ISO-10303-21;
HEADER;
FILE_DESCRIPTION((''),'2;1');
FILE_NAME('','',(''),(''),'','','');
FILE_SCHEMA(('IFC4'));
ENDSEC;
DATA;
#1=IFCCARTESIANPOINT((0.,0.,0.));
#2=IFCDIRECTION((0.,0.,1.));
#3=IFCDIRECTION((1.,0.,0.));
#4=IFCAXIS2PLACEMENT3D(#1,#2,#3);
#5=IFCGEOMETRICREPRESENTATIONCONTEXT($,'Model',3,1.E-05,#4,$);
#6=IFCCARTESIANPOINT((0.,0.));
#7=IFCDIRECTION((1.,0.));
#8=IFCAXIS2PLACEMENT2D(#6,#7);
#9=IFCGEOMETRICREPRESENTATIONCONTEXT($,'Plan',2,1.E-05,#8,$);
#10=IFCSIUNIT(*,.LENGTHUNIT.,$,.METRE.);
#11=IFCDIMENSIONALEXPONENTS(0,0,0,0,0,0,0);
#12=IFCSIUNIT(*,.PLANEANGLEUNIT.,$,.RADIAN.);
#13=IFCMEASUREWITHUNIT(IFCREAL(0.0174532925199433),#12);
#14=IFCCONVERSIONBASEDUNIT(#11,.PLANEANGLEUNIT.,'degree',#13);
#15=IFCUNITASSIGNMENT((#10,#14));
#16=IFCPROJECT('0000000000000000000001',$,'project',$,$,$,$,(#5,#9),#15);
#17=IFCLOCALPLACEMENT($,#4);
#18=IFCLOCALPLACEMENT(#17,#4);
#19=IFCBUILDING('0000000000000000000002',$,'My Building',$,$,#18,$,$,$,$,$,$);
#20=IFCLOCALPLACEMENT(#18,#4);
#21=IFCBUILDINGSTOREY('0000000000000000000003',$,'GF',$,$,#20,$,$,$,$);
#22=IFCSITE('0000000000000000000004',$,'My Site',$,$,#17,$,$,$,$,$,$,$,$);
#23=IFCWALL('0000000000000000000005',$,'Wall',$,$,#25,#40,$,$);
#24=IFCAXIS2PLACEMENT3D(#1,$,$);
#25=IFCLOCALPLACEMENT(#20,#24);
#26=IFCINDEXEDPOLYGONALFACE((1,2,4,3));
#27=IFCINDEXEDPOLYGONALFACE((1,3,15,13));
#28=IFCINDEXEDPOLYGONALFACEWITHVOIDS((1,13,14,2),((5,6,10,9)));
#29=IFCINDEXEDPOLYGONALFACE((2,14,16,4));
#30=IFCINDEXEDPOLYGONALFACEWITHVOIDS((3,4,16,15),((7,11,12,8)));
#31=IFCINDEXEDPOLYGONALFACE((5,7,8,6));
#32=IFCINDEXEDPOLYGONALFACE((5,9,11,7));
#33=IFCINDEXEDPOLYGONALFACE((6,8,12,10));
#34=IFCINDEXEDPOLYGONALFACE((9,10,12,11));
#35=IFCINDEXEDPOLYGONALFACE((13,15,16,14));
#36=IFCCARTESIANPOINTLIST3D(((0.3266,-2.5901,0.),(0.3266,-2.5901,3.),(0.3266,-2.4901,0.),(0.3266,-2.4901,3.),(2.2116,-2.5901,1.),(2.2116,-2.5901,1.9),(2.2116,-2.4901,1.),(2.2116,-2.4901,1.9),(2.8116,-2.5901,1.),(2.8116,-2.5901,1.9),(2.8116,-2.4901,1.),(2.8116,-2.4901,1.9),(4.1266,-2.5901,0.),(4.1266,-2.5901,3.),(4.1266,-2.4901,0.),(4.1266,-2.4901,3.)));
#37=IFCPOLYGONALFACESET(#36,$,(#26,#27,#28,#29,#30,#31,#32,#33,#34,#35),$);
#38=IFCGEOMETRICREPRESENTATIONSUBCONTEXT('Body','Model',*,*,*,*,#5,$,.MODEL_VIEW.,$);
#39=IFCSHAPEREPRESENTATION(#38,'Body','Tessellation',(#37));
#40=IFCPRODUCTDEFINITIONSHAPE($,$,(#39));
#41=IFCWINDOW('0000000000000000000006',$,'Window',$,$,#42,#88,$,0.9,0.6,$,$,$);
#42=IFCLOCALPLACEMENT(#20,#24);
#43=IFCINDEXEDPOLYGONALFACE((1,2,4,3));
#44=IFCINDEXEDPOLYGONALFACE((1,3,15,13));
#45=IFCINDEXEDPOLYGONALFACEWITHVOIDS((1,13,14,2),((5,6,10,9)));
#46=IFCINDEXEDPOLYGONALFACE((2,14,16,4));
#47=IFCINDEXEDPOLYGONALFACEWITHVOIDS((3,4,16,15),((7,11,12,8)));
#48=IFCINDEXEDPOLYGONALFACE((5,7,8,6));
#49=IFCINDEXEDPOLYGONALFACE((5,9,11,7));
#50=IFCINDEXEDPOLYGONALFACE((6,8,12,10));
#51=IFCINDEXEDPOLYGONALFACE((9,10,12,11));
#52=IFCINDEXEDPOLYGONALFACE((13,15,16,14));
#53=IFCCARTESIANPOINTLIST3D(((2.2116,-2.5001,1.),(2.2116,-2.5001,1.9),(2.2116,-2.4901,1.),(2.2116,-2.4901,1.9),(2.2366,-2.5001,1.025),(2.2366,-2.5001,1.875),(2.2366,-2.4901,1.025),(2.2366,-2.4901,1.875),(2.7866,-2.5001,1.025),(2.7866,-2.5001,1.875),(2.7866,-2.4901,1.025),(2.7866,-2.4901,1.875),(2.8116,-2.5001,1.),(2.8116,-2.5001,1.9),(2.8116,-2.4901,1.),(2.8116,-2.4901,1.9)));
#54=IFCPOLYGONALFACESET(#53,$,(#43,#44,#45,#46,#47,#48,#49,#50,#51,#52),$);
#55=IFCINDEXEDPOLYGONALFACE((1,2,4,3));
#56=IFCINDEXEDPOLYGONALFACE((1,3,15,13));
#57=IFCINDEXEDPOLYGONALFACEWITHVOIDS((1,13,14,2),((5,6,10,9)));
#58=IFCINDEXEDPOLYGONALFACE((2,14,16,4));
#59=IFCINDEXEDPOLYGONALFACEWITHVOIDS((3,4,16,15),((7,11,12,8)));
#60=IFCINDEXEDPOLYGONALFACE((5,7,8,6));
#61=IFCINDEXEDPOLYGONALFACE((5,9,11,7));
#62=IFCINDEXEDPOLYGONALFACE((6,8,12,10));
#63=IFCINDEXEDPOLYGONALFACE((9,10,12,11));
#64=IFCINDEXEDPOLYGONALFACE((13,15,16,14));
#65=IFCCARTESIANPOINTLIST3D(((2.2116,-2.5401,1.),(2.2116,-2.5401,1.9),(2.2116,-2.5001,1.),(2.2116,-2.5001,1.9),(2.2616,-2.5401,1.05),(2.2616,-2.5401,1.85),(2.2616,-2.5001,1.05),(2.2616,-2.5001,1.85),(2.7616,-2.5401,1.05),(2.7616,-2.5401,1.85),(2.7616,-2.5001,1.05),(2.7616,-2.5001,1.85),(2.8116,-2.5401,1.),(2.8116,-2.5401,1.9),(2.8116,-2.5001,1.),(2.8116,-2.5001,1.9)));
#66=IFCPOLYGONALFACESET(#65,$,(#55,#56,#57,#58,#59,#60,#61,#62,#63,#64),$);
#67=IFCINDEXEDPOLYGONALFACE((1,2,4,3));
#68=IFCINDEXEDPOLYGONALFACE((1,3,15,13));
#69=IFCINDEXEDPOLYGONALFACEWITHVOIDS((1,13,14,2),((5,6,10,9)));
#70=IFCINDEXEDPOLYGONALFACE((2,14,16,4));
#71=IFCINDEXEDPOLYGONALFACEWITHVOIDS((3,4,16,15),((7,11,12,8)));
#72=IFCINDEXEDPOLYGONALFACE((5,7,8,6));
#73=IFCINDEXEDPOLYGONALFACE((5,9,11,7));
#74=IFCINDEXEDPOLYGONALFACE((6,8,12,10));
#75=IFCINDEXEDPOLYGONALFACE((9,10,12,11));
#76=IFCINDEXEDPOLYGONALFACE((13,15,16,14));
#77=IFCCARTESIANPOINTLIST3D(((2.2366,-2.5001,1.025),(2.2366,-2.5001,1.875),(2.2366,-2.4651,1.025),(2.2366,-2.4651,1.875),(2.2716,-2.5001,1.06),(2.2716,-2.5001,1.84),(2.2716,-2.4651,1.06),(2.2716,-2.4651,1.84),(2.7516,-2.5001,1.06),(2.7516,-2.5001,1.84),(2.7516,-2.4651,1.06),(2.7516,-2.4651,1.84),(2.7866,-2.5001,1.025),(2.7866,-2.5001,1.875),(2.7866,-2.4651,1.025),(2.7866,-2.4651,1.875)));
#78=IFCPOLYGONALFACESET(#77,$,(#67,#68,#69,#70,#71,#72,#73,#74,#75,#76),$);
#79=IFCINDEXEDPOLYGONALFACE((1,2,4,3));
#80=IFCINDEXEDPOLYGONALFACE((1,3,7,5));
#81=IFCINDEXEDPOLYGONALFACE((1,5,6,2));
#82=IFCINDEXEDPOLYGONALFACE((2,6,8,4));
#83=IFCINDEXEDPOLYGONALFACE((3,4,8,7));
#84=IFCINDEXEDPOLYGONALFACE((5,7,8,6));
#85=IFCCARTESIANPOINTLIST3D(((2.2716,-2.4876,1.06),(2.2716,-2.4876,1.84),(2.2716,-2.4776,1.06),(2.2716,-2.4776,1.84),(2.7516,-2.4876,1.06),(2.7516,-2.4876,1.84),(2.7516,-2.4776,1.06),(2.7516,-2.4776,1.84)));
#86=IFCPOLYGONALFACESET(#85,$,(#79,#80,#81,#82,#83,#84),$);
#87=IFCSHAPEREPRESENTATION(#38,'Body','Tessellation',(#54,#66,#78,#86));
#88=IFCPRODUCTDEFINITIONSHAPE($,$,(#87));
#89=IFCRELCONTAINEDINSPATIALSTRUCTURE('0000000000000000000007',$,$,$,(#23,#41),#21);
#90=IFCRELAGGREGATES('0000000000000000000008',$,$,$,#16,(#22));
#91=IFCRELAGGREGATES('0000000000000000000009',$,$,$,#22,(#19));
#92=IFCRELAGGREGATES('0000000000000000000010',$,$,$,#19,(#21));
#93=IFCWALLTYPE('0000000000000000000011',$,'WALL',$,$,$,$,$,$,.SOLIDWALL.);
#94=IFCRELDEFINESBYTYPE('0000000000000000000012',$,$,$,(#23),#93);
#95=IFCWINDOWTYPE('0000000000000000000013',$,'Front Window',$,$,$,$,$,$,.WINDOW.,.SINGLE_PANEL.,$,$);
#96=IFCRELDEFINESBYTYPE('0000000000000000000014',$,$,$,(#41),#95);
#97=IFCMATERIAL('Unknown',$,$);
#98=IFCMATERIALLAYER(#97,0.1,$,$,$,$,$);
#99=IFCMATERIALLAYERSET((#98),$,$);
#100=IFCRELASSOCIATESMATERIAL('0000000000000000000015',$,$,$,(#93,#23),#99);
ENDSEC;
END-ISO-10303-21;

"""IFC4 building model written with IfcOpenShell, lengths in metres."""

from ifc_helpers import new_model, entity, si_unit, converted_unit, frame, origin_with_axes, origin_2d_with_axis, place, context, subcontext, project, spatial, line, indexed_curve, outline, extrude, shape, source, transform, mapped, material, layer, layer_set, layer_usage, type_object, type_shapes, element, fill, save


model = new_model("IFC4")

# Units and contexts
model_context = context("Model", 3, precision=1e-05, world=origin_with_axes())
plan_context = context("Plan", 2, precision=1e-05, world=origin_2d_with_axis())
body_context_1 = subcontext(model_context, "Body", "Model", "MODEL_VIEW")
body_context_2 = subcontext(plan_context, "Body", "Plan", "PLAN_VIEW")
ifc_project = project(units=[si_unit("LENGTHUNIT", "METRE"), converted_unit("PLANEANGLEUNIT", "degree", entity("IfcReal", 0.0174532925199433), si_unit("PLANEANGLEUNIT", "RADIAN"), dimensions=[0, 0, 0, 0, 0, 0, 0])], contexts=[model_context, plan_context])

# Site, building, storey
site_placement = place(None, origin_with_axes())
site = spatial("IfcSite", under=ifc_project, at=site_placement, Name="My Site")
building_placement = place(site_placement, origin_with_axes())
building = spatial("IfcBuilding", under=site, at=building_placement, Name="My Building")
storey_placement = place(building_placement, origin_with_axes())
storey = spatial("IfcBuildingStorey", under=building, at=storey_placement, Name="GF")

# Shared definitions
ifc_material = material(Name="Unknown")

# Shared definitions
ifc_layer_1 = layer(ifc_material, 0.1)
ifc_layer_set_1 = layer_set([ifc_layer_1])
wall_type = type_object("IfcWallType", Name="WALL", PredefinedType="SOLIDWALL", material=ifc_layer_set_1)
shared_shape_1 = source(origin_with_axes(), body_context_1, "Body", "SweptSolid", [
    extrude(outline(indexed_curve([(0.0, 0.0), (0.6, 0.0), (0.6, 0.9), (0.0, 0.9)], segments=[line(1, 2, 3, 4, 1)])), frame((0.0, -0.6, 0.0), z_axis=(0.0, -1.0, 0.0), x_axis=(1.0, 0.0, 0.0)), (0.0, 0.0, -1.0), 1.2),
])
window_type_1 = type_object("IfcWindowType", Name="Front Window", PartitioningType="SINGLE_PANEL", PredefinedType="WINDOW")
shared_shape_2 = source(origin_with_axes(), body_context_1, "Body", "SweptSolid", [
    extrude(outline(indexed_curve([(0.0, 0.0), (0.6, 0.0), (0.6, 0.9), (0.0, 0.9)], segments=[line(1, 2, 3, 4, 1)]), holes=[indexed_curve([(0.025, 0.025), (0.575, 0.025), (0.575, 0.875), (0.025, 0.875)], segments=[line(1, 2, 3, 4, 1)])]), frame((0.0, 0.09, 0.0), z_axis=(0.0, -1.0, 0.0), x_axis=(1.0, 0.0, 0.0)), (0.0, 0.0, -1.0), 0.01),
    extrude(outline(indexed_curve([(0.0, 0.0), (0.6, 0.0), (0.6, 0.9), (0.0, 0.9)], segments=[line(1, 2, 3, 4, 1)]), holes=[indexed_curve([(0.05, 0.05), (0.55, 0.05), (0.55, 0.85), (0.05, 0.85)], segments=[line(1, 2, 3, 4, 1)])]), frame((0.0, 0.05, 0.0), z_axis=(0.0, -1.0, 0.0), x_axis=(1.0, 0.0, 0.0)), (0.0, 0.0, -1.0), 0.04),
    extrude(outline(indexed_curve([(0.0, 0.0), (0.55, 0.0), (0.55, 0.85), (0.0, 0.85)], segments=[line(1, 2, 3, 4, 1)]), holes=[indexed_curve([(0.035, 0.035), (0.515, 0.035), (0.515, 0.815), (0.035, 0.815)], segments=[line(1, 2, 3, 4, 1)])]), frame((0.025, 0.09, 0.025), z_axis=(0.0, -1.0, 0.0), x_axis=(1.0, 0.0, 0.0)), (0.0, 0.0, -1.0), 0.035),
    extrude(outline(indexed_curve([(0.035, 0.035), (0.515, 0.035), (0.515, 0.815), (0.035, 0.815)], segments=[line(1, 2, 3, 4, 1)])), frame((0.025, 0.1025, 0.025), z_axis=(0.0, -1.0, 0.0), x_axis=(1.0, 0.0, 0.0)), (0.0, 0.0, -1.0), 0.01),
])
shared_shape_3 = source(origin_with_axes(), body_context_2, "Body", "Curve2D", [
    entity("IfcIndexedPolyCurve", entity("IfcCartesianPointList2D", [[0.05, 0.05], [0.55, 0.05]])),
    entity("IfcIndexedPolyCurve", entity("IfcCartesianPointList2D", [[0.0, 0.1], [0.025, 0.1], [0.025, 0.09], [0.05, 0.09], [0.05, 0.05], [0.0, 0.05]]), [entity("IfcLineIndex", [1, 2, 3, 4, 5, 6, 1])]),
    entity("IfcIndexedPolyCurve", entity("IfcCartesianPointList2D", [[0.6, 0.1], [0.575, 0.1], [0.575, 0.09], [0.55, 0.09], [0.55, 0.05], [0.6, 0.05]]), [entity("IfcLineIndex", [1, 2, 3, 4, 5, 6, 1])]),
    entity("IfcIndexedPolyCurve", entity("IfcCartesianPointList2D", [[0.025, 0.09], [0.06, 0.09], [0.06, 0.125], [0.025, 0.125]]), [entity("IfcLineIndex", [1, 2, 3, 4, 1])]),
    entity("IfcIndexedPolyCurve", entity("IfcCartesianPointList2D", [[0.575, 0.09], [0.54, 0.09], [0.54, 0.125], [0.575, 0.125]]), [entity("IfcLineIndex", [1, 2, 3, 4, 1])]),
    entity("IfcIndexedPolyCurve", entity("IfcCartesianPointList2D", [[0.06, 0.09], [0.54, 0.09]])),
    entity("IfcIndexedPolyCurve", entity("IfcCartesianPointList2D", [[0.06, 0.125], [0.54, 0.125]])),
    entity("IfcIndexedPolyCurve", entity("IfcCartesianPointList2D", [[0.06, 0.1075], [0.54, 0.1075]])),
])
type_shapes(window_type_1, [shared_shape_2, shared_shape_3])

# Wall, opening, window
ifc_layer_usage_1 = layer_usage(ifc_layer_set_1, "AXIS2", "POSITIVE", 0.0)
wall_1_placement = place(storey_placement, frame((0.3266, -2.5901, 0.0), z_axis=(0.0, 0.0, 1.0), x_axis=(1.0, 0.0, 0.0)))
wall_1 = element("IfcWall", 1, at=wall_1_placement, inside=storey, type_object=wall_type, material=ifc_layer_usage_1, Name="Wall", context=body_context_1, shape_type="SweptSolid", body=[
    extrude(outline(indexed_curve([(0.0, 0.0), (0.0, 0.1), (3.8, 0.1), (3.8, 0.0)], segments=[line(1, 2, 3, 4, 1)])), origin_with_axes(), (0.0, 0.0, 1.0), 3.0),
])
opening_1_placement = place(wall_1_placement, frame((1.8849, 0.0, 1.0), z_axis=(0.0, 0.0, 1.0), x_axis=(1.0, 0.0, 0.0)))
opening_1 = element("IfcOpeningElement", 2, at=opening_1_placement, cuts=wall_1, PredefinedType="OPENING", context=body_context_1, shape_type="MappedRepresentation", body=[
    mapped(shared_shape_1, transform((0.0, 0.0, 0.0), x_axis=(1.0, 0.0, 0.0), y_axis=(0.0, 1.0, 0.0), z_axis=(0.0, 0.0, 1.0), scale=1.0)),
])
window_1_placement = place(opening_1_placement, origin_with_axes())
window_1 = element("IfcWindow", 3, at=window_1_placement, inside=storey, type_object=window_type_1, Name="Window", OverallHeight=0.9, OverallWidth=0.6, shapes=[
    shape(body_context_1, "Body", "MappedRepresentation", [mapped(shared_shape_2, transform((0.0, 0.0, 0.0), x_axis=(1.0, 0.0, 0.0), y_axis=(0.0, 1.0, 0.0), z_axis=(0.0, 0.0, 1.0), scale=1.0))]),
    shape(body_context_2, "Body", "MappedRepresentation", [mapped(shared_shape_3, transform((0.0, 0.0, 0.0), x_axis=(1.0, 0.0, 0.0), y_axis=(0.0, 1.0, 0.0), z_axis=(0.0, 0.0, 1.0), scale=1.0))]),
])
fill(opening_1, window_1)

save(model, "model.ifc")
